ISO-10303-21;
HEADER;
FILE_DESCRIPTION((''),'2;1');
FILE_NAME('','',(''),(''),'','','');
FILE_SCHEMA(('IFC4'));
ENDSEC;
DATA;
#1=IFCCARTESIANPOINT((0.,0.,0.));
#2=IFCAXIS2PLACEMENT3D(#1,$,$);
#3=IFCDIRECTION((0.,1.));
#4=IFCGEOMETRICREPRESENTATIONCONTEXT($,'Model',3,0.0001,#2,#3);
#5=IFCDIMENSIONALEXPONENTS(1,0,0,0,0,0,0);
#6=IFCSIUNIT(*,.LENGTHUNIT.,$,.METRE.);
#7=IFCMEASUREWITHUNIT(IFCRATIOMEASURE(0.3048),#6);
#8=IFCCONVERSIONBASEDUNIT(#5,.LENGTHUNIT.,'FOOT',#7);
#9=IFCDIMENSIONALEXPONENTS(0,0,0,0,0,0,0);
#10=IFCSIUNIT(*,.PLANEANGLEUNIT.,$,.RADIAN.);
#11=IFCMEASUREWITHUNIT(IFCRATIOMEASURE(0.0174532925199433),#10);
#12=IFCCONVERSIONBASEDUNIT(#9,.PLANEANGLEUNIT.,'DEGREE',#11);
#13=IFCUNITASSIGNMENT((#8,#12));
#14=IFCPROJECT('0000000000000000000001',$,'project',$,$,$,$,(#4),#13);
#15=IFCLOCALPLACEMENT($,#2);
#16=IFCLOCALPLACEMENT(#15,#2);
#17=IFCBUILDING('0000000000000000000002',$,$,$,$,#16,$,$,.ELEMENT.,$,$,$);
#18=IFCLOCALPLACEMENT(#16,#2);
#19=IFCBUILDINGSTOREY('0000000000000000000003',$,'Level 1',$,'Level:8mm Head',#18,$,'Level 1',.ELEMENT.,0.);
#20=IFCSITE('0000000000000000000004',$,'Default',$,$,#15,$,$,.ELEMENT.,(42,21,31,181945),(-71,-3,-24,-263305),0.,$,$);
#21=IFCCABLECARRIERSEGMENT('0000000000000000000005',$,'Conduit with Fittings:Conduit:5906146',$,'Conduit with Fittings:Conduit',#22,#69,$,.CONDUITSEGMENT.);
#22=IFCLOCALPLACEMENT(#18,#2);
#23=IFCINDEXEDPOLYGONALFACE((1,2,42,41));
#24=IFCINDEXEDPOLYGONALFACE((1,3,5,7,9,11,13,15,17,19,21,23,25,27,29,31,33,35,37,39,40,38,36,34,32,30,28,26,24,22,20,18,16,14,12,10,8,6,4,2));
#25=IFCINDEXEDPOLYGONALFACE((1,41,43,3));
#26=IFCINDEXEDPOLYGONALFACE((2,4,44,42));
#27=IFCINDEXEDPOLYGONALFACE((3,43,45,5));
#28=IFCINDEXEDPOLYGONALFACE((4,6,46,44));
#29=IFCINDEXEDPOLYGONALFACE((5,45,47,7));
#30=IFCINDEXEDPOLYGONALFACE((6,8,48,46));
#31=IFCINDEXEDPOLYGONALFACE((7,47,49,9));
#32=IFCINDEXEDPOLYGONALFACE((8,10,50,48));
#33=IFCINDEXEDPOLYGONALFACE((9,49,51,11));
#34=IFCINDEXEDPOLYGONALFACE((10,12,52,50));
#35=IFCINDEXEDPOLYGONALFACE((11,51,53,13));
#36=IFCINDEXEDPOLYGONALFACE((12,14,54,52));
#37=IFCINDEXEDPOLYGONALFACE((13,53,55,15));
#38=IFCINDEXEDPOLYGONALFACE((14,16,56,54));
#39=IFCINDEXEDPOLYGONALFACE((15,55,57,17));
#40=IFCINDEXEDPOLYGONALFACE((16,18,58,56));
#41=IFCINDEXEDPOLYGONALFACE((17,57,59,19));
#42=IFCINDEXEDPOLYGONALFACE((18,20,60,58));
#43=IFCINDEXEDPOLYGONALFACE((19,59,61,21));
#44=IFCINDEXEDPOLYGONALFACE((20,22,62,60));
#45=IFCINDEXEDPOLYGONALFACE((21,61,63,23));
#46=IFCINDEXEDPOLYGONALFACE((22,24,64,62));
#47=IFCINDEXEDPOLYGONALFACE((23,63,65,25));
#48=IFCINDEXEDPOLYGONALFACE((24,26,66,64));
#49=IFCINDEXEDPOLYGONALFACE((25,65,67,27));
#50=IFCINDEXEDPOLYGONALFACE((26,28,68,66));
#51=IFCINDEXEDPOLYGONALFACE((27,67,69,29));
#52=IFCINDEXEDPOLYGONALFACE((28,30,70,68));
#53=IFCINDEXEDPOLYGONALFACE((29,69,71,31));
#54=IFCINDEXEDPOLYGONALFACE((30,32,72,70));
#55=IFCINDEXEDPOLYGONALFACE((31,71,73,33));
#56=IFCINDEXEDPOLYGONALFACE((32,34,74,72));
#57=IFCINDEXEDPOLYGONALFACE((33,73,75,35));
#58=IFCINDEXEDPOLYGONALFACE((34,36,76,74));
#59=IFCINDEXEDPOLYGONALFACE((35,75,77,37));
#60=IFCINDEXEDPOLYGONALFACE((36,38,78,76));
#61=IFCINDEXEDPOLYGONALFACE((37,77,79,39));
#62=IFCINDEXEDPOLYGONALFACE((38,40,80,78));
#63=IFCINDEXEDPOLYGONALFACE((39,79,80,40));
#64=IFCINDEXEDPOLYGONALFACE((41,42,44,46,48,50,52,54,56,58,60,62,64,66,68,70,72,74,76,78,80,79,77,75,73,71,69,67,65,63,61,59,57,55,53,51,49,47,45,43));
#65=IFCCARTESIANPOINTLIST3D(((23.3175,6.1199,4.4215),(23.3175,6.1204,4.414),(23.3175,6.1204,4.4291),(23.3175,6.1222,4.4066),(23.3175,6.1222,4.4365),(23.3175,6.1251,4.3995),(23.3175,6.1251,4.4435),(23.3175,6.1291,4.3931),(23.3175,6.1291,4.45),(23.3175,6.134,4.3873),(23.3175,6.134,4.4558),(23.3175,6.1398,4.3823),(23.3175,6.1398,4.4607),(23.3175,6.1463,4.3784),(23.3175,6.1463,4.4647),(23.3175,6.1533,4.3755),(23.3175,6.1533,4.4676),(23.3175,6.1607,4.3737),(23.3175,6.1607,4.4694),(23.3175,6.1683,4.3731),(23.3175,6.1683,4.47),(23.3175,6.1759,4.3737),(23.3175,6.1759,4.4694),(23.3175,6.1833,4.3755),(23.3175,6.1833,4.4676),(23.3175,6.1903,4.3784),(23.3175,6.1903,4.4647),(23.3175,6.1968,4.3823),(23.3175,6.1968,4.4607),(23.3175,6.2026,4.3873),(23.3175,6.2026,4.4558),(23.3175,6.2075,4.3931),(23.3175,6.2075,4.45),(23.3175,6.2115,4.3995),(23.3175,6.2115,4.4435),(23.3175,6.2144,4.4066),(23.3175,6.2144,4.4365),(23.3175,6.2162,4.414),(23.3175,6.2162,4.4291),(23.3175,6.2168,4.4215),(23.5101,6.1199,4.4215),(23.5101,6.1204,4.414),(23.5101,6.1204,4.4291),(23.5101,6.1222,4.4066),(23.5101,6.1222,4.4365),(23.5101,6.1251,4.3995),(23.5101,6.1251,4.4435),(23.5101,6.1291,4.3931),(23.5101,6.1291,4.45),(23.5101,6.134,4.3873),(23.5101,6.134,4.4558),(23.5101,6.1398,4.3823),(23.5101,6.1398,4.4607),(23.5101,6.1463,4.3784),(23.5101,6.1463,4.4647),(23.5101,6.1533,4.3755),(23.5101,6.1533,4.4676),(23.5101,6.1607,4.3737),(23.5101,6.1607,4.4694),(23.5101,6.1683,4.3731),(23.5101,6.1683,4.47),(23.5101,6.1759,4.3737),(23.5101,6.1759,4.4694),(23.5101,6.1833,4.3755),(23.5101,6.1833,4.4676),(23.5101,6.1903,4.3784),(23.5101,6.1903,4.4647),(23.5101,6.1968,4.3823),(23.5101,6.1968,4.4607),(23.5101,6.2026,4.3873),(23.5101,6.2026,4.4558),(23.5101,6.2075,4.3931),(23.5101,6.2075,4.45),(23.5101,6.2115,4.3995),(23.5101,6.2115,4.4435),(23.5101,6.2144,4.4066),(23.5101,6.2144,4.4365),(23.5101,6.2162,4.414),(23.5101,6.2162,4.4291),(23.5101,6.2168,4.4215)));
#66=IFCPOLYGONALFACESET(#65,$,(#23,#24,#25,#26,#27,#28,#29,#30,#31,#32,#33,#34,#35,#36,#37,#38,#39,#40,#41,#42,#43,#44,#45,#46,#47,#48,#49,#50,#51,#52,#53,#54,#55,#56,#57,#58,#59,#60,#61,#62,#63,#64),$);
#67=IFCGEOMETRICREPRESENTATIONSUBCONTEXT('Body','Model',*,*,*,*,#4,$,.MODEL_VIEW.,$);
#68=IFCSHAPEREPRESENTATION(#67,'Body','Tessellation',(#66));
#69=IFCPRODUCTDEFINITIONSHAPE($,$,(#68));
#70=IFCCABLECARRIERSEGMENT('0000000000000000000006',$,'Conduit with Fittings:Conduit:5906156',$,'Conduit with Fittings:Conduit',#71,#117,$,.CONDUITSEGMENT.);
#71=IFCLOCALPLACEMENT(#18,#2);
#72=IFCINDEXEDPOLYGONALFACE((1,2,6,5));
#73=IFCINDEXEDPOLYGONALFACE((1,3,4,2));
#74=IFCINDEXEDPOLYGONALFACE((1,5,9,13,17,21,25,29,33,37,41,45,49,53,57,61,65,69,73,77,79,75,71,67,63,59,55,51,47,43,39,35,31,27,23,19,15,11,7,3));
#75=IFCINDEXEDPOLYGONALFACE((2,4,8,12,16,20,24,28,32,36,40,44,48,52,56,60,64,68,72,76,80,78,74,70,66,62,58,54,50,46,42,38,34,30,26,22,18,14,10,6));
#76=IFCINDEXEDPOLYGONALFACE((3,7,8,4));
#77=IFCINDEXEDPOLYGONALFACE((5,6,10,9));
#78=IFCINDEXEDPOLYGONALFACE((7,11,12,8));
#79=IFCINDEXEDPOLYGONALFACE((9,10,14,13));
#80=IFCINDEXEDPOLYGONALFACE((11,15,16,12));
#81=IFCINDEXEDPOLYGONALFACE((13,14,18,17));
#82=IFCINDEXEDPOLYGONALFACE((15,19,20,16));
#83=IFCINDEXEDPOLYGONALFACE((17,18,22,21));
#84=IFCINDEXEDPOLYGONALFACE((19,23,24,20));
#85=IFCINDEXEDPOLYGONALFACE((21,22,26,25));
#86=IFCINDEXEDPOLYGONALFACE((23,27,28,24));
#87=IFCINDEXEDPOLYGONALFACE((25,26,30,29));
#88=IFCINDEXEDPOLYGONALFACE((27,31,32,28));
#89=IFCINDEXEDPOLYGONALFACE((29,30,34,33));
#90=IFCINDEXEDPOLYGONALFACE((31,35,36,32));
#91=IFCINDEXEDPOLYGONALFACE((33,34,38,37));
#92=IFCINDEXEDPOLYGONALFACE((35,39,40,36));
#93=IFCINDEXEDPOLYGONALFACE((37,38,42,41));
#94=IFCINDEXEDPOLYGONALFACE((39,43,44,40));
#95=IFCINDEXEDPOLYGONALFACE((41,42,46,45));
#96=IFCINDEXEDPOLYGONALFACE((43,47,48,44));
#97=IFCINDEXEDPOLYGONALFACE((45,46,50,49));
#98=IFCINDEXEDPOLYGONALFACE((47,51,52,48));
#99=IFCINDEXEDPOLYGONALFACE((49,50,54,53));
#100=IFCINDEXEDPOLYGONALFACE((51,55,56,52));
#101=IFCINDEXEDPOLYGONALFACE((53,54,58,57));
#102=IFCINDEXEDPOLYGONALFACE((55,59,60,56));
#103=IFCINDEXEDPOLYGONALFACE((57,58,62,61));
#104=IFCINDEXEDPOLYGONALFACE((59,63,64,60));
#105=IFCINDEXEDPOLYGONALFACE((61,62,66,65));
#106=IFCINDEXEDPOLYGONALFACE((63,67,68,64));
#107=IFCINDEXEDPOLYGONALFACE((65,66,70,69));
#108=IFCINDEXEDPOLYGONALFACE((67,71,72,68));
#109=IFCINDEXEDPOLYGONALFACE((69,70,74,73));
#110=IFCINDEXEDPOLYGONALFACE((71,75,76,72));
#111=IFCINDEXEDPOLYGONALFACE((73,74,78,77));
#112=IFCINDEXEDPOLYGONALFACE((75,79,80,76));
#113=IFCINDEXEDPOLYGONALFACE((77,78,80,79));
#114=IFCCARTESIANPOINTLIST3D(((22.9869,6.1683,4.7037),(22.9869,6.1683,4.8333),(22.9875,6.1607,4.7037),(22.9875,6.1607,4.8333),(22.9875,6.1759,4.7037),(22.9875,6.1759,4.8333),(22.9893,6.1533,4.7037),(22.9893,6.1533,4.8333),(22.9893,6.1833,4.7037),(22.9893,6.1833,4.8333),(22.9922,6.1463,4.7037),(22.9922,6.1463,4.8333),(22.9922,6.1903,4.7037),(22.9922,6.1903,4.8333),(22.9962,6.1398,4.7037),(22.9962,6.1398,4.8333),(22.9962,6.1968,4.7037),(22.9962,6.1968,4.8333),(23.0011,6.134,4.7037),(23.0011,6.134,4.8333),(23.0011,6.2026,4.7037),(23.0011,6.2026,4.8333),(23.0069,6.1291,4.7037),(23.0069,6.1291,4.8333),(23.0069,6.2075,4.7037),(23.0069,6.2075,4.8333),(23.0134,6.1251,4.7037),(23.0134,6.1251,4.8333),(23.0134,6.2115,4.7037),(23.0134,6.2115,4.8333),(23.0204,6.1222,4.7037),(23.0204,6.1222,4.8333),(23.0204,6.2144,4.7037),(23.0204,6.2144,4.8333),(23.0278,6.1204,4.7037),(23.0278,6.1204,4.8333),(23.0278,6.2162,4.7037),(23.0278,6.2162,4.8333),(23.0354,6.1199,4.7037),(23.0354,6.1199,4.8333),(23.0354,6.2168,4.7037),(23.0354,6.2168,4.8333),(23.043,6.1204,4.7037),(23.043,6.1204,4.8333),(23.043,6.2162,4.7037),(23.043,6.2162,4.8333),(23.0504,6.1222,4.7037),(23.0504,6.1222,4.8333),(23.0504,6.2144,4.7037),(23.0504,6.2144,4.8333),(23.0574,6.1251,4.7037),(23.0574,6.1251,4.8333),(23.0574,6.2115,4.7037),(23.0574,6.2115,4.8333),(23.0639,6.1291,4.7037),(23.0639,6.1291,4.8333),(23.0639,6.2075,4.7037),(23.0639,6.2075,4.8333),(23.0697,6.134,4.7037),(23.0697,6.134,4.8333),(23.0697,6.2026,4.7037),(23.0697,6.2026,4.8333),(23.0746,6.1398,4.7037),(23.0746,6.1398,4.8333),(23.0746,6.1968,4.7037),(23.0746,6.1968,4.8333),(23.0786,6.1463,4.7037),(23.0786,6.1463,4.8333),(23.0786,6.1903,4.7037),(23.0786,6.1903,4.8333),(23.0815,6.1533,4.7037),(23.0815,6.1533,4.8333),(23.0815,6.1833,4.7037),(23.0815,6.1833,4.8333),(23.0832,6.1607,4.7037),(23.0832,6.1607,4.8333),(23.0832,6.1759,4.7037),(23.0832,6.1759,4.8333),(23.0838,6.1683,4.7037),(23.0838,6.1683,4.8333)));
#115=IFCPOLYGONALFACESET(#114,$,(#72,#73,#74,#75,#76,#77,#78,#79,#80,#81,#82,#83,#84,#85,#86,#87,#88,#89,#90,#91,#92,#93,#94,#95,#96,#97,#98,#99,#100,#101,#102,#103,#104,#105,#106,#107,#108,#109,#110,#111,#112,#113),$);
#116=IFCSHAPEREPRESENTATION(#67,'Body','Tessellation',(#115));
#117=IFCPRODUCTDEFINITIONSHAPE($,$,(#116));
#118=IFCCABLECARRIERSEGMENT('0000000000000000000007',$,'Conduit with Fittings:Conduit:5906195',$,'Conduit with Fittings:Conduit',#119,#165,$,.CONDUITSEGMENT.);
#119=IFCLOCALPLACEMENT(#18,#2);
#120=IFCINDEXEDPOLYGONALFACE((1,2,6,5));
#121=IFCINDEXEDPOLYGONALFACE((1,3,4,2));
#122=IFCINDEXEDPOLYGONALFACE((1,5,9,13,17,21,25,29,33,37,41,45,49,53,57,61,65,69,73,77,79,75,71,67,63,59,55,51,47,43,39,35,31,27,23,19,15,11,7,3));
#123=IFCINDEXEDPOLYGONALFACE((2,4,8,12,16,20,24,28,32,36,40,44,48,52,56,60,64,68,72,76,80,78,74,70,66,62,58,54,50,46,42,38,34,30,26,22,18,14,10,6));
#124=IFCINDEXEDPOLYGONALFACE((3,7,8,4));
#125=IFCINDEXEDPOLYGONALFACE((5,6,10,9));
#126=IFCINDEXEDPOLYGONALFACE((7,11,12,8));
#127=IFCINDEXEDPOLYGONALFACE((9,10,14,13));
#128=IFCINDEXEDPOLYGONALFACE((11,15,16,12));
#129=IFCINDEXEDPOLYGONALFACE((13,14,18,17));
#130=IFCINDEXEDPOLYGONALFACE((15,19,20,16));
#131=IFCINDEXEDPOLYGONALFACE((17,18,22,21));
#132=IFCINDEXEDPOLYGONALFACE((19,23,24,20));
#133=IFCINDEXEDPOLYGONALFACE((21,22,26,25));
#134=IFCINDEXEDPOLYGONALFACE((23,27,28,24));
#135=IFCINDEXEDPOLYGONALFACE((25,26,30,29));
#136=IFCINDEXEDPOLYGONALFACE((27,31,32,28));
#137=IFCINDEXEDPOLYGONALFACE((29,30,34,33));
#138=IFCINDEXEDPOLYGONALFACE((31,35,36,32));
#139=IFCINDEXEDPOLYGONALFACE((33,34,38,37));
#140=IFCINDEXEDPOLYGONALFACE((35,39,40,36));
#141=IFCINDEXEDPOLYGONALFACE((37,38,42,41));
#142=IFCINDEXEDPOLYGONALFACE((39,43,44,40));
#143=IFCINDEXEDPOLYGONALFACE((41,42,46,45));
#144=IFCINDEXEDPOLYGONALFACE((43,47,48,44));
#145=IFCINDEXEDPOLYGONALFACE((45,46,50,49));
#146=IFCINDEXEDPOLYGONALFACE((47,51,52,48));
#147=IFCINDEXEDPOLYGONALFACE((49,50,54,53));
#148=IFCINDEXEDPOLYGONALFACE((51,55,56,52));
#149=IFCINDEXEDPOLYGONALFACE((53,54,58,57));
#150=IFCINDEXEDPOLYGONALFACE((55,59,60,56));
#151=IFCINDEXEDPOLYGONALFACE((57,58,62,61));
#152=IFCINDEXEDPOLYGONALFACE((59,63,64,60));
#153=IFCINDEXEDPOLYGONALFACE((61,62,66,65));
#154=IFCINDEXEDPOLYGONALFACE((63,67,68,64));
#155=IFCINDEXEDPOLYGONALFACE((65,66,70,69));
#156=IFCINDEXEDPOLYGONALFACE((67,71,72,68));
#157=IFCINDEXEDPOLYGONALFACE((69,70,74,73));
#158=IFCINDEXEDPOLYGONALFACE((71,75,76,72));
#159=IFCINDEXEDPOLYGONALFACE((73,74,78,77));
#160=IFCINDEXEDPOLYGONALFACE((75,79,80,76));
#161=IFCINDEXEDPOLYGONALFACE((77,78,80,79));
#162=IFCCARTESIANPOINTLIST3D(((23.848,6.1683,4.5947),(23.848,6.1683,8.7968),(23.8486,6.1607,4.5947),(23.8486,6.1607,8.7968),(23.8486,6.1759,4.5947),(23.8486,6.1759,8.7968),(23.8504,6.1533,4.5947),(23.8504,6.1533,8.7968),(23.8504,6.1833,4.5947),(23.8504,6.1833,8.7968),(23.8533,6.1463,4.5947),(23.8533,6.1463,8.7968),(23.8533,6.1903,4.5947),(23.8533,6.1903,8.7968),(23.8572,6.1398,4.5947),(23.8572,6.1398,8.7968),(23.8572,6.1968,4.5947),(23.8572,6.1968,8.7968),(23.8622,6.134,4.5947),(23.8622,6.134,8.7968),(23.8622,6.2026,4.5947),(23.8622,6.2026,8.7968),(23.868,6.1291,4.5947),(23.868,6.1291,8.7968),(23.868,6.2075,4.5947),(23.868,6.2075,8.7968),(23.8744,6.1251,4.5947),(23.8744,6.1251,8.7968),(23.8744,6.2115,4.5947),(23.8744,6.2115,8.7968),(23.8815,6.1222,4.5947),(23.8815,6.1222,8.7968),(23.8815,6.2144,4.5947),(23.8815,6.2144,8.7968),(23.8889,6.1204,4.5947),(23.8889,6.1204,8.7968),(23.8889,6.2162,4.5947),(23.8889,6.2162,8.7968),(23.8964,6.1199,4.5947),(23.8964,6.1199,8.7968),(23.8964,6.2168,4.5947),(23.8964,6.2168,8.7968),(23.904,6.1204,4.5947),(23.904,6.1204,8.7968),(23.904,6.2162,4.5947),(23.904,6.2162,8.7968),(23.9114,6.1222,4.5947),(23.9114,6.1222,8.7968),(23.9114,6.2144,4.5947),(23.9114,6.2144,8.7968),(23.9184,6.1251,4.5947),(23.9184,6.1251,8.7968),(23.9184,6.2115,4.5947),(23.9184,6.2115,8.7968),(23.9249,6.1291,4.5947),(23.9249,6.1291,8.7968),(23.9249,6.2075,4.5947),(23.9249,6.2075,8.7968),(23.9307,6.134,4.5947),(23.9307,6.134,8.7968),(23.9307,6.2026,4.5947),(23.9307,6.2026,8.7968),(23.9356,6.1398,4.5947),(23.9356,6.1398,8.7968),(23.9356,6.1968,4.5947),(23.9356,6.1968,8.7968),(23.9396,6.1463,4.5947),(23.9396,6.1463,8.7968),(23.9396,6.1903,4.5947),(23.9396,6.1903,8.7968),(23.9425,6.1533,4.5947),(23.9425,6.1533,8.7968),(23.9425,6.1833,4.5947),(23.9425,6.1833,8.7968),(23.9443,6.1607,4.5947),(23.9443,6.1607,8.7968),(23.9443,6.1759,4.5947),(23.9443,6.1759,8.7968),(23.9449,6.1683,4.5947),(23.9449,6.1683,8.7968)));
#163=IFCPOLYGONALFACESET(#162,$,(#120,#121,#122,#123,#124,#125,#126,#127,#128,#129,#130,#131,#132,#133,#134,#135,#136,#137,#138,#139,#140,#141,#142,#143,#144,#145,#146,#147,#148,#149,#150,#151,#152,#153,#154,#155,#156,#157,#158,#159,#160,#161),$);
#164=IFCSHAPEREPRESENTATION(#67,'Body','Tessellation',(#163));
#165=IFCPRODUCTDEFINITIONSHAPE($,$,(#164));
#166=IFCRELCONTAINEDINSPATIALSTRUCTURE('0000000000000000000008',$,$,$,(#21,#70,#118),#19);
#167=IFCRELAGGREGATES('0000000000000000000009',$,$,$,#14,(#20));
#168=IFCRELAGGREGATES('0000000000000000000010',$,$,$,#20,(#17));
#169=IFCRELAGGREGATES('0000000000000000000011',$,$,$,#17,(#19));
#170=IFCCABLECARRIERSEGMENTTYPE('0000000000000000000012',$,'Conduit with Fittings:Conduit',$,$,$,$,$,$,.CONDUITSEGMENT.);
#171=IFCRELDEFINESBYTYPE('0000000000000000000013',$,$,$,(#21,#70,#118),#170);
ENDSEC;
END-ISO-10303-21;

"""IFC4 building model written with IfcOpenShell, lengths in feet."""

from ifc_helpers import new_model, entity, si_unit, converted_unit, direction, frame, origin, place, context, subcontext, project, spatial, indexed_curve, outline, extrude, type_object, element, save


model = new_model("IFC4")

# Units and contexts
model_context = context("Model", 3, precision=0.0001, world=origin(), true_north=direction((0.0, 1.0)))
body_context = subcontext(model_context, "Body", "Model", "MODEL_VIEW")
ifc_project = project(units=[converted_unit("LENGTHUNIT", "FOOT", entity("IfcRatioMeasure", 0.3048), si_unit("LENGTHUNIT", "METRE"), dimensions=[1, 0, 0, 0, 0, 0, 0]), converted_unit("PLANEANGLEUNIT", "DEGREE", entity("IfcRatioMeasure", 0.0174532925199433), si_unit("PLANEANGLEUNIT", "RADIAN"), dimensions=[0, 0, 0, 0, 0, 0, 0])], contexts=[model_context])

# Site, building, storey
site_placement = place(None, origin())
site = spatial("IfcSite", under=ifc_project, at=site_placement, Name="Default", CompositionType="ELEMENT", RefLatitude=(42, 21, 31, 181945), RefLongitude=(-71, -3, -24, -263305), RefElevation=0.0)
building_placement = place(site_placement, origin())
building = spatial("IfcBuilding", under=site, at=building_placement, CompositionType="ELEMENT")
storey_placement = place(building_placement, origin())
storey = spatial("IfcBuildingStorey", under=building, at=storey_placement, Name="Level 1", ObjectType="Level:8mm Head", LongName="Level 1", CompositionType="ELEMENT", Elevation=0.0)

# Cable carrier segments
cable_carrier_segment_type_1 = type_object("IfcCableCarrierSegmentType", Name="Conduit with Fittings:Conduit", PredefinedType="CONDUITSEGMENT")
cable_carrier_segment_1_placement = place(storey_placement, origin())
element("IfcCableCarrierSegment", 1, at=cable_carrier_segment_1_placement, inside=storey, type_object=cable_carrier_segment_type_1, Name="Conduit with Fittings:Conduit:5906146", ObjectType="Conduit with Fittings:Conduit", PredefinedType="CONDUITSEGMENT", context=body_context, shape_type="SweptSolid", body=[
    extrude(outline(indexed_curve([(0.0485, 0.0), (0.0479, 0.0076), (0.0461, 0.015), (0.0432, 0.022), (0.0392, 0.0285), (0.0343, 0.0343), (0.0285, 0.0392), (0.022, 0.0432), (0.015, 0.0461), (0.0076, 0.0479), (0.0, 0.0485), (-0.0076, 0.0479), (-0.015, 0.0461), (-0.022, 0.0432), (-0.0285, 0.0392), (-0.0343, 0.0343), (-0.0392, 0.0285), (-0.0432, 0.022), (-0.0461, 0.015), (-0.0479, 0.0076), (-0.0485, 0.0), (-0.0479, -0.0076), (-0.0461, -0.015), (-0.0432, -0.022), (-0.0392, -0.0285), (-0.0343, -0.0343), (-0.0285, -0.0392), (-0.022, -0.0432), (-0.015, -0.0461), (-0.0076, -0.0479), (0.0, -0.0485), (0.0076, -0.0479), (0.015, -0.0461), (0.022, -0.0432), (0.0285, -0.0392), (0.0343, -0.0343), (0.0392, -0.0285), (0.0432, -0.022), (0.0461, -0.015), (0.0479, -0.0076), (0.0485, 0.0)], self_intersect=False)), frame((23.3175, 6.1683, 4.4215), z_axis=(1.0, 0.0, 0.0), x_axis=(0.0, 1.0, 0.0)), (0.0, 0.0, 1.0), 0.1926),
])
cable_carrier_segment_2_placement = place(storey_placement, origin())
element("IfcCableCarrierSegment", 2, at=cable_carrier_segment_2_placement, inside=storey, type_object=cable_carrier_segment_type_1, Name="Conduit with Fittings:Conduit:5906156", ObjectType="Conduit with Fittings:Conduit", PredefinedType="CONDUITSEGMENT", context=body_context, shape_type="SweptSolid", body=[
    extrude(outline(indexed_curve([(0.0485, 0.0), (0.0479, 0.0076), (0.0461, 0.015), (0.0432, 0.022), (0.0392, 0.0285), (0.0343, 0.0343), (0.0285, 0.0392), (0.022, 0.0432), (0.015, 0.0461), (0.0076, 0.0479), (0.0, 0.0485), (-0.0076, 0.0479), (-0.015, 0.0461), (-0.022, 0.0432), (-0.0285, 0.0392), (-0.0343, 0.0343), (-0.0392, 0.0285), (-0.0432, 0.022), (-0.0461, 0.015), (-0.0479, 0.0076), (-0.0485, 0.0), (-0.0479, -0.0076), (-0.0461, -0.015), (-0.0432, -0.022), (-0.0392, -0.0285), (-0.0343, -0.0343), (-0.0285, -0.0392), (-0.022, -0.0432), (-0.015, -0.0461), (-0.0076, -0.0479), (0.0, -0.0485), (0.0076, -0.0479), (0.015, -0.0461), (0.022, -0.0432), (0.0285, -0.0392), (0.0343, -0.0343), (0.0392, -0.0285), (0.0432, -0.022), (0.0461, -0.015), (0.0479, -0.0076), (0.0485, 0.0)], self_intersect=False)), frame((23.0354, 6.1683, 4.7037), z_axis=(0.0, 0.0, 1.0), x_axis=(-1.0, 0.0, 0.0)), (0.0, 0.0, 1.0), 0.1296),
])
cable_carrier_segment_3_placement = place(storey_placement, origin())
element("IfcCableCarrierSegment", 3, at=cable_carrier_segment_3_placement, inside=storey, type_object=cable_carrier_segment_type_1, Name="Conduit with Fittings:Conduit:5906195", ObjectType="Conduit with Fittings:Conduit", PredefinedType="CONDUITSEGMENT", context=body_context, shape_type="SweptSolid", body=[
    extrude(outline(indexed_curve([(0.0485, 0.0), (0.0479, 0.0076), (0.0461, 0.015), (0.0432, 0.022), (0.0392, 0.0285), (0.0343, 0.0343), (0.0285, 0.0392), (0.022, 0.0432), (0.015, 0.0461), (0.0076, 0.0479), (0.0, 0.0485), (-0.0076, 0.0479), (-0.015, 0.0461), (-0.022, 0.0432), (-0.0285, 0.0392), (-0.0343, 0.0343), (-0.0392, 0.0285), (-0.0432, 0.022), (-0.0461, 0.015), (-0.0479, 0.0076), (-0.0485, 0.0), (-0.0479, -0.0076), (-0.0461, -0.015), (-0.0432, -0.022), (-0.0392, -0.0285), (-0.0343, -0.0343), (-0.0285, -0.0392), (-0.022, -0.0432), (-0.015, -0.0461), (-0.0076, -0.0479), (0.0, -0.0485), (0.0076, -0.0479), (0.015, -0.0461), (0.022, -0.0432), (0.0285, -0.0392), (0.0343, -0.0343), (0.0392, -0.0285), (0.0432, -0.022), (0.0461, -0.015), (0.0479, -0.0076), (0.0485, 0.0)], self_intersect=False)), frame((23.8964, 6.1683, 4.5947)), (0.0, 0.0, 1.0), 4.2022),
])

save(model, "model.ifc")
